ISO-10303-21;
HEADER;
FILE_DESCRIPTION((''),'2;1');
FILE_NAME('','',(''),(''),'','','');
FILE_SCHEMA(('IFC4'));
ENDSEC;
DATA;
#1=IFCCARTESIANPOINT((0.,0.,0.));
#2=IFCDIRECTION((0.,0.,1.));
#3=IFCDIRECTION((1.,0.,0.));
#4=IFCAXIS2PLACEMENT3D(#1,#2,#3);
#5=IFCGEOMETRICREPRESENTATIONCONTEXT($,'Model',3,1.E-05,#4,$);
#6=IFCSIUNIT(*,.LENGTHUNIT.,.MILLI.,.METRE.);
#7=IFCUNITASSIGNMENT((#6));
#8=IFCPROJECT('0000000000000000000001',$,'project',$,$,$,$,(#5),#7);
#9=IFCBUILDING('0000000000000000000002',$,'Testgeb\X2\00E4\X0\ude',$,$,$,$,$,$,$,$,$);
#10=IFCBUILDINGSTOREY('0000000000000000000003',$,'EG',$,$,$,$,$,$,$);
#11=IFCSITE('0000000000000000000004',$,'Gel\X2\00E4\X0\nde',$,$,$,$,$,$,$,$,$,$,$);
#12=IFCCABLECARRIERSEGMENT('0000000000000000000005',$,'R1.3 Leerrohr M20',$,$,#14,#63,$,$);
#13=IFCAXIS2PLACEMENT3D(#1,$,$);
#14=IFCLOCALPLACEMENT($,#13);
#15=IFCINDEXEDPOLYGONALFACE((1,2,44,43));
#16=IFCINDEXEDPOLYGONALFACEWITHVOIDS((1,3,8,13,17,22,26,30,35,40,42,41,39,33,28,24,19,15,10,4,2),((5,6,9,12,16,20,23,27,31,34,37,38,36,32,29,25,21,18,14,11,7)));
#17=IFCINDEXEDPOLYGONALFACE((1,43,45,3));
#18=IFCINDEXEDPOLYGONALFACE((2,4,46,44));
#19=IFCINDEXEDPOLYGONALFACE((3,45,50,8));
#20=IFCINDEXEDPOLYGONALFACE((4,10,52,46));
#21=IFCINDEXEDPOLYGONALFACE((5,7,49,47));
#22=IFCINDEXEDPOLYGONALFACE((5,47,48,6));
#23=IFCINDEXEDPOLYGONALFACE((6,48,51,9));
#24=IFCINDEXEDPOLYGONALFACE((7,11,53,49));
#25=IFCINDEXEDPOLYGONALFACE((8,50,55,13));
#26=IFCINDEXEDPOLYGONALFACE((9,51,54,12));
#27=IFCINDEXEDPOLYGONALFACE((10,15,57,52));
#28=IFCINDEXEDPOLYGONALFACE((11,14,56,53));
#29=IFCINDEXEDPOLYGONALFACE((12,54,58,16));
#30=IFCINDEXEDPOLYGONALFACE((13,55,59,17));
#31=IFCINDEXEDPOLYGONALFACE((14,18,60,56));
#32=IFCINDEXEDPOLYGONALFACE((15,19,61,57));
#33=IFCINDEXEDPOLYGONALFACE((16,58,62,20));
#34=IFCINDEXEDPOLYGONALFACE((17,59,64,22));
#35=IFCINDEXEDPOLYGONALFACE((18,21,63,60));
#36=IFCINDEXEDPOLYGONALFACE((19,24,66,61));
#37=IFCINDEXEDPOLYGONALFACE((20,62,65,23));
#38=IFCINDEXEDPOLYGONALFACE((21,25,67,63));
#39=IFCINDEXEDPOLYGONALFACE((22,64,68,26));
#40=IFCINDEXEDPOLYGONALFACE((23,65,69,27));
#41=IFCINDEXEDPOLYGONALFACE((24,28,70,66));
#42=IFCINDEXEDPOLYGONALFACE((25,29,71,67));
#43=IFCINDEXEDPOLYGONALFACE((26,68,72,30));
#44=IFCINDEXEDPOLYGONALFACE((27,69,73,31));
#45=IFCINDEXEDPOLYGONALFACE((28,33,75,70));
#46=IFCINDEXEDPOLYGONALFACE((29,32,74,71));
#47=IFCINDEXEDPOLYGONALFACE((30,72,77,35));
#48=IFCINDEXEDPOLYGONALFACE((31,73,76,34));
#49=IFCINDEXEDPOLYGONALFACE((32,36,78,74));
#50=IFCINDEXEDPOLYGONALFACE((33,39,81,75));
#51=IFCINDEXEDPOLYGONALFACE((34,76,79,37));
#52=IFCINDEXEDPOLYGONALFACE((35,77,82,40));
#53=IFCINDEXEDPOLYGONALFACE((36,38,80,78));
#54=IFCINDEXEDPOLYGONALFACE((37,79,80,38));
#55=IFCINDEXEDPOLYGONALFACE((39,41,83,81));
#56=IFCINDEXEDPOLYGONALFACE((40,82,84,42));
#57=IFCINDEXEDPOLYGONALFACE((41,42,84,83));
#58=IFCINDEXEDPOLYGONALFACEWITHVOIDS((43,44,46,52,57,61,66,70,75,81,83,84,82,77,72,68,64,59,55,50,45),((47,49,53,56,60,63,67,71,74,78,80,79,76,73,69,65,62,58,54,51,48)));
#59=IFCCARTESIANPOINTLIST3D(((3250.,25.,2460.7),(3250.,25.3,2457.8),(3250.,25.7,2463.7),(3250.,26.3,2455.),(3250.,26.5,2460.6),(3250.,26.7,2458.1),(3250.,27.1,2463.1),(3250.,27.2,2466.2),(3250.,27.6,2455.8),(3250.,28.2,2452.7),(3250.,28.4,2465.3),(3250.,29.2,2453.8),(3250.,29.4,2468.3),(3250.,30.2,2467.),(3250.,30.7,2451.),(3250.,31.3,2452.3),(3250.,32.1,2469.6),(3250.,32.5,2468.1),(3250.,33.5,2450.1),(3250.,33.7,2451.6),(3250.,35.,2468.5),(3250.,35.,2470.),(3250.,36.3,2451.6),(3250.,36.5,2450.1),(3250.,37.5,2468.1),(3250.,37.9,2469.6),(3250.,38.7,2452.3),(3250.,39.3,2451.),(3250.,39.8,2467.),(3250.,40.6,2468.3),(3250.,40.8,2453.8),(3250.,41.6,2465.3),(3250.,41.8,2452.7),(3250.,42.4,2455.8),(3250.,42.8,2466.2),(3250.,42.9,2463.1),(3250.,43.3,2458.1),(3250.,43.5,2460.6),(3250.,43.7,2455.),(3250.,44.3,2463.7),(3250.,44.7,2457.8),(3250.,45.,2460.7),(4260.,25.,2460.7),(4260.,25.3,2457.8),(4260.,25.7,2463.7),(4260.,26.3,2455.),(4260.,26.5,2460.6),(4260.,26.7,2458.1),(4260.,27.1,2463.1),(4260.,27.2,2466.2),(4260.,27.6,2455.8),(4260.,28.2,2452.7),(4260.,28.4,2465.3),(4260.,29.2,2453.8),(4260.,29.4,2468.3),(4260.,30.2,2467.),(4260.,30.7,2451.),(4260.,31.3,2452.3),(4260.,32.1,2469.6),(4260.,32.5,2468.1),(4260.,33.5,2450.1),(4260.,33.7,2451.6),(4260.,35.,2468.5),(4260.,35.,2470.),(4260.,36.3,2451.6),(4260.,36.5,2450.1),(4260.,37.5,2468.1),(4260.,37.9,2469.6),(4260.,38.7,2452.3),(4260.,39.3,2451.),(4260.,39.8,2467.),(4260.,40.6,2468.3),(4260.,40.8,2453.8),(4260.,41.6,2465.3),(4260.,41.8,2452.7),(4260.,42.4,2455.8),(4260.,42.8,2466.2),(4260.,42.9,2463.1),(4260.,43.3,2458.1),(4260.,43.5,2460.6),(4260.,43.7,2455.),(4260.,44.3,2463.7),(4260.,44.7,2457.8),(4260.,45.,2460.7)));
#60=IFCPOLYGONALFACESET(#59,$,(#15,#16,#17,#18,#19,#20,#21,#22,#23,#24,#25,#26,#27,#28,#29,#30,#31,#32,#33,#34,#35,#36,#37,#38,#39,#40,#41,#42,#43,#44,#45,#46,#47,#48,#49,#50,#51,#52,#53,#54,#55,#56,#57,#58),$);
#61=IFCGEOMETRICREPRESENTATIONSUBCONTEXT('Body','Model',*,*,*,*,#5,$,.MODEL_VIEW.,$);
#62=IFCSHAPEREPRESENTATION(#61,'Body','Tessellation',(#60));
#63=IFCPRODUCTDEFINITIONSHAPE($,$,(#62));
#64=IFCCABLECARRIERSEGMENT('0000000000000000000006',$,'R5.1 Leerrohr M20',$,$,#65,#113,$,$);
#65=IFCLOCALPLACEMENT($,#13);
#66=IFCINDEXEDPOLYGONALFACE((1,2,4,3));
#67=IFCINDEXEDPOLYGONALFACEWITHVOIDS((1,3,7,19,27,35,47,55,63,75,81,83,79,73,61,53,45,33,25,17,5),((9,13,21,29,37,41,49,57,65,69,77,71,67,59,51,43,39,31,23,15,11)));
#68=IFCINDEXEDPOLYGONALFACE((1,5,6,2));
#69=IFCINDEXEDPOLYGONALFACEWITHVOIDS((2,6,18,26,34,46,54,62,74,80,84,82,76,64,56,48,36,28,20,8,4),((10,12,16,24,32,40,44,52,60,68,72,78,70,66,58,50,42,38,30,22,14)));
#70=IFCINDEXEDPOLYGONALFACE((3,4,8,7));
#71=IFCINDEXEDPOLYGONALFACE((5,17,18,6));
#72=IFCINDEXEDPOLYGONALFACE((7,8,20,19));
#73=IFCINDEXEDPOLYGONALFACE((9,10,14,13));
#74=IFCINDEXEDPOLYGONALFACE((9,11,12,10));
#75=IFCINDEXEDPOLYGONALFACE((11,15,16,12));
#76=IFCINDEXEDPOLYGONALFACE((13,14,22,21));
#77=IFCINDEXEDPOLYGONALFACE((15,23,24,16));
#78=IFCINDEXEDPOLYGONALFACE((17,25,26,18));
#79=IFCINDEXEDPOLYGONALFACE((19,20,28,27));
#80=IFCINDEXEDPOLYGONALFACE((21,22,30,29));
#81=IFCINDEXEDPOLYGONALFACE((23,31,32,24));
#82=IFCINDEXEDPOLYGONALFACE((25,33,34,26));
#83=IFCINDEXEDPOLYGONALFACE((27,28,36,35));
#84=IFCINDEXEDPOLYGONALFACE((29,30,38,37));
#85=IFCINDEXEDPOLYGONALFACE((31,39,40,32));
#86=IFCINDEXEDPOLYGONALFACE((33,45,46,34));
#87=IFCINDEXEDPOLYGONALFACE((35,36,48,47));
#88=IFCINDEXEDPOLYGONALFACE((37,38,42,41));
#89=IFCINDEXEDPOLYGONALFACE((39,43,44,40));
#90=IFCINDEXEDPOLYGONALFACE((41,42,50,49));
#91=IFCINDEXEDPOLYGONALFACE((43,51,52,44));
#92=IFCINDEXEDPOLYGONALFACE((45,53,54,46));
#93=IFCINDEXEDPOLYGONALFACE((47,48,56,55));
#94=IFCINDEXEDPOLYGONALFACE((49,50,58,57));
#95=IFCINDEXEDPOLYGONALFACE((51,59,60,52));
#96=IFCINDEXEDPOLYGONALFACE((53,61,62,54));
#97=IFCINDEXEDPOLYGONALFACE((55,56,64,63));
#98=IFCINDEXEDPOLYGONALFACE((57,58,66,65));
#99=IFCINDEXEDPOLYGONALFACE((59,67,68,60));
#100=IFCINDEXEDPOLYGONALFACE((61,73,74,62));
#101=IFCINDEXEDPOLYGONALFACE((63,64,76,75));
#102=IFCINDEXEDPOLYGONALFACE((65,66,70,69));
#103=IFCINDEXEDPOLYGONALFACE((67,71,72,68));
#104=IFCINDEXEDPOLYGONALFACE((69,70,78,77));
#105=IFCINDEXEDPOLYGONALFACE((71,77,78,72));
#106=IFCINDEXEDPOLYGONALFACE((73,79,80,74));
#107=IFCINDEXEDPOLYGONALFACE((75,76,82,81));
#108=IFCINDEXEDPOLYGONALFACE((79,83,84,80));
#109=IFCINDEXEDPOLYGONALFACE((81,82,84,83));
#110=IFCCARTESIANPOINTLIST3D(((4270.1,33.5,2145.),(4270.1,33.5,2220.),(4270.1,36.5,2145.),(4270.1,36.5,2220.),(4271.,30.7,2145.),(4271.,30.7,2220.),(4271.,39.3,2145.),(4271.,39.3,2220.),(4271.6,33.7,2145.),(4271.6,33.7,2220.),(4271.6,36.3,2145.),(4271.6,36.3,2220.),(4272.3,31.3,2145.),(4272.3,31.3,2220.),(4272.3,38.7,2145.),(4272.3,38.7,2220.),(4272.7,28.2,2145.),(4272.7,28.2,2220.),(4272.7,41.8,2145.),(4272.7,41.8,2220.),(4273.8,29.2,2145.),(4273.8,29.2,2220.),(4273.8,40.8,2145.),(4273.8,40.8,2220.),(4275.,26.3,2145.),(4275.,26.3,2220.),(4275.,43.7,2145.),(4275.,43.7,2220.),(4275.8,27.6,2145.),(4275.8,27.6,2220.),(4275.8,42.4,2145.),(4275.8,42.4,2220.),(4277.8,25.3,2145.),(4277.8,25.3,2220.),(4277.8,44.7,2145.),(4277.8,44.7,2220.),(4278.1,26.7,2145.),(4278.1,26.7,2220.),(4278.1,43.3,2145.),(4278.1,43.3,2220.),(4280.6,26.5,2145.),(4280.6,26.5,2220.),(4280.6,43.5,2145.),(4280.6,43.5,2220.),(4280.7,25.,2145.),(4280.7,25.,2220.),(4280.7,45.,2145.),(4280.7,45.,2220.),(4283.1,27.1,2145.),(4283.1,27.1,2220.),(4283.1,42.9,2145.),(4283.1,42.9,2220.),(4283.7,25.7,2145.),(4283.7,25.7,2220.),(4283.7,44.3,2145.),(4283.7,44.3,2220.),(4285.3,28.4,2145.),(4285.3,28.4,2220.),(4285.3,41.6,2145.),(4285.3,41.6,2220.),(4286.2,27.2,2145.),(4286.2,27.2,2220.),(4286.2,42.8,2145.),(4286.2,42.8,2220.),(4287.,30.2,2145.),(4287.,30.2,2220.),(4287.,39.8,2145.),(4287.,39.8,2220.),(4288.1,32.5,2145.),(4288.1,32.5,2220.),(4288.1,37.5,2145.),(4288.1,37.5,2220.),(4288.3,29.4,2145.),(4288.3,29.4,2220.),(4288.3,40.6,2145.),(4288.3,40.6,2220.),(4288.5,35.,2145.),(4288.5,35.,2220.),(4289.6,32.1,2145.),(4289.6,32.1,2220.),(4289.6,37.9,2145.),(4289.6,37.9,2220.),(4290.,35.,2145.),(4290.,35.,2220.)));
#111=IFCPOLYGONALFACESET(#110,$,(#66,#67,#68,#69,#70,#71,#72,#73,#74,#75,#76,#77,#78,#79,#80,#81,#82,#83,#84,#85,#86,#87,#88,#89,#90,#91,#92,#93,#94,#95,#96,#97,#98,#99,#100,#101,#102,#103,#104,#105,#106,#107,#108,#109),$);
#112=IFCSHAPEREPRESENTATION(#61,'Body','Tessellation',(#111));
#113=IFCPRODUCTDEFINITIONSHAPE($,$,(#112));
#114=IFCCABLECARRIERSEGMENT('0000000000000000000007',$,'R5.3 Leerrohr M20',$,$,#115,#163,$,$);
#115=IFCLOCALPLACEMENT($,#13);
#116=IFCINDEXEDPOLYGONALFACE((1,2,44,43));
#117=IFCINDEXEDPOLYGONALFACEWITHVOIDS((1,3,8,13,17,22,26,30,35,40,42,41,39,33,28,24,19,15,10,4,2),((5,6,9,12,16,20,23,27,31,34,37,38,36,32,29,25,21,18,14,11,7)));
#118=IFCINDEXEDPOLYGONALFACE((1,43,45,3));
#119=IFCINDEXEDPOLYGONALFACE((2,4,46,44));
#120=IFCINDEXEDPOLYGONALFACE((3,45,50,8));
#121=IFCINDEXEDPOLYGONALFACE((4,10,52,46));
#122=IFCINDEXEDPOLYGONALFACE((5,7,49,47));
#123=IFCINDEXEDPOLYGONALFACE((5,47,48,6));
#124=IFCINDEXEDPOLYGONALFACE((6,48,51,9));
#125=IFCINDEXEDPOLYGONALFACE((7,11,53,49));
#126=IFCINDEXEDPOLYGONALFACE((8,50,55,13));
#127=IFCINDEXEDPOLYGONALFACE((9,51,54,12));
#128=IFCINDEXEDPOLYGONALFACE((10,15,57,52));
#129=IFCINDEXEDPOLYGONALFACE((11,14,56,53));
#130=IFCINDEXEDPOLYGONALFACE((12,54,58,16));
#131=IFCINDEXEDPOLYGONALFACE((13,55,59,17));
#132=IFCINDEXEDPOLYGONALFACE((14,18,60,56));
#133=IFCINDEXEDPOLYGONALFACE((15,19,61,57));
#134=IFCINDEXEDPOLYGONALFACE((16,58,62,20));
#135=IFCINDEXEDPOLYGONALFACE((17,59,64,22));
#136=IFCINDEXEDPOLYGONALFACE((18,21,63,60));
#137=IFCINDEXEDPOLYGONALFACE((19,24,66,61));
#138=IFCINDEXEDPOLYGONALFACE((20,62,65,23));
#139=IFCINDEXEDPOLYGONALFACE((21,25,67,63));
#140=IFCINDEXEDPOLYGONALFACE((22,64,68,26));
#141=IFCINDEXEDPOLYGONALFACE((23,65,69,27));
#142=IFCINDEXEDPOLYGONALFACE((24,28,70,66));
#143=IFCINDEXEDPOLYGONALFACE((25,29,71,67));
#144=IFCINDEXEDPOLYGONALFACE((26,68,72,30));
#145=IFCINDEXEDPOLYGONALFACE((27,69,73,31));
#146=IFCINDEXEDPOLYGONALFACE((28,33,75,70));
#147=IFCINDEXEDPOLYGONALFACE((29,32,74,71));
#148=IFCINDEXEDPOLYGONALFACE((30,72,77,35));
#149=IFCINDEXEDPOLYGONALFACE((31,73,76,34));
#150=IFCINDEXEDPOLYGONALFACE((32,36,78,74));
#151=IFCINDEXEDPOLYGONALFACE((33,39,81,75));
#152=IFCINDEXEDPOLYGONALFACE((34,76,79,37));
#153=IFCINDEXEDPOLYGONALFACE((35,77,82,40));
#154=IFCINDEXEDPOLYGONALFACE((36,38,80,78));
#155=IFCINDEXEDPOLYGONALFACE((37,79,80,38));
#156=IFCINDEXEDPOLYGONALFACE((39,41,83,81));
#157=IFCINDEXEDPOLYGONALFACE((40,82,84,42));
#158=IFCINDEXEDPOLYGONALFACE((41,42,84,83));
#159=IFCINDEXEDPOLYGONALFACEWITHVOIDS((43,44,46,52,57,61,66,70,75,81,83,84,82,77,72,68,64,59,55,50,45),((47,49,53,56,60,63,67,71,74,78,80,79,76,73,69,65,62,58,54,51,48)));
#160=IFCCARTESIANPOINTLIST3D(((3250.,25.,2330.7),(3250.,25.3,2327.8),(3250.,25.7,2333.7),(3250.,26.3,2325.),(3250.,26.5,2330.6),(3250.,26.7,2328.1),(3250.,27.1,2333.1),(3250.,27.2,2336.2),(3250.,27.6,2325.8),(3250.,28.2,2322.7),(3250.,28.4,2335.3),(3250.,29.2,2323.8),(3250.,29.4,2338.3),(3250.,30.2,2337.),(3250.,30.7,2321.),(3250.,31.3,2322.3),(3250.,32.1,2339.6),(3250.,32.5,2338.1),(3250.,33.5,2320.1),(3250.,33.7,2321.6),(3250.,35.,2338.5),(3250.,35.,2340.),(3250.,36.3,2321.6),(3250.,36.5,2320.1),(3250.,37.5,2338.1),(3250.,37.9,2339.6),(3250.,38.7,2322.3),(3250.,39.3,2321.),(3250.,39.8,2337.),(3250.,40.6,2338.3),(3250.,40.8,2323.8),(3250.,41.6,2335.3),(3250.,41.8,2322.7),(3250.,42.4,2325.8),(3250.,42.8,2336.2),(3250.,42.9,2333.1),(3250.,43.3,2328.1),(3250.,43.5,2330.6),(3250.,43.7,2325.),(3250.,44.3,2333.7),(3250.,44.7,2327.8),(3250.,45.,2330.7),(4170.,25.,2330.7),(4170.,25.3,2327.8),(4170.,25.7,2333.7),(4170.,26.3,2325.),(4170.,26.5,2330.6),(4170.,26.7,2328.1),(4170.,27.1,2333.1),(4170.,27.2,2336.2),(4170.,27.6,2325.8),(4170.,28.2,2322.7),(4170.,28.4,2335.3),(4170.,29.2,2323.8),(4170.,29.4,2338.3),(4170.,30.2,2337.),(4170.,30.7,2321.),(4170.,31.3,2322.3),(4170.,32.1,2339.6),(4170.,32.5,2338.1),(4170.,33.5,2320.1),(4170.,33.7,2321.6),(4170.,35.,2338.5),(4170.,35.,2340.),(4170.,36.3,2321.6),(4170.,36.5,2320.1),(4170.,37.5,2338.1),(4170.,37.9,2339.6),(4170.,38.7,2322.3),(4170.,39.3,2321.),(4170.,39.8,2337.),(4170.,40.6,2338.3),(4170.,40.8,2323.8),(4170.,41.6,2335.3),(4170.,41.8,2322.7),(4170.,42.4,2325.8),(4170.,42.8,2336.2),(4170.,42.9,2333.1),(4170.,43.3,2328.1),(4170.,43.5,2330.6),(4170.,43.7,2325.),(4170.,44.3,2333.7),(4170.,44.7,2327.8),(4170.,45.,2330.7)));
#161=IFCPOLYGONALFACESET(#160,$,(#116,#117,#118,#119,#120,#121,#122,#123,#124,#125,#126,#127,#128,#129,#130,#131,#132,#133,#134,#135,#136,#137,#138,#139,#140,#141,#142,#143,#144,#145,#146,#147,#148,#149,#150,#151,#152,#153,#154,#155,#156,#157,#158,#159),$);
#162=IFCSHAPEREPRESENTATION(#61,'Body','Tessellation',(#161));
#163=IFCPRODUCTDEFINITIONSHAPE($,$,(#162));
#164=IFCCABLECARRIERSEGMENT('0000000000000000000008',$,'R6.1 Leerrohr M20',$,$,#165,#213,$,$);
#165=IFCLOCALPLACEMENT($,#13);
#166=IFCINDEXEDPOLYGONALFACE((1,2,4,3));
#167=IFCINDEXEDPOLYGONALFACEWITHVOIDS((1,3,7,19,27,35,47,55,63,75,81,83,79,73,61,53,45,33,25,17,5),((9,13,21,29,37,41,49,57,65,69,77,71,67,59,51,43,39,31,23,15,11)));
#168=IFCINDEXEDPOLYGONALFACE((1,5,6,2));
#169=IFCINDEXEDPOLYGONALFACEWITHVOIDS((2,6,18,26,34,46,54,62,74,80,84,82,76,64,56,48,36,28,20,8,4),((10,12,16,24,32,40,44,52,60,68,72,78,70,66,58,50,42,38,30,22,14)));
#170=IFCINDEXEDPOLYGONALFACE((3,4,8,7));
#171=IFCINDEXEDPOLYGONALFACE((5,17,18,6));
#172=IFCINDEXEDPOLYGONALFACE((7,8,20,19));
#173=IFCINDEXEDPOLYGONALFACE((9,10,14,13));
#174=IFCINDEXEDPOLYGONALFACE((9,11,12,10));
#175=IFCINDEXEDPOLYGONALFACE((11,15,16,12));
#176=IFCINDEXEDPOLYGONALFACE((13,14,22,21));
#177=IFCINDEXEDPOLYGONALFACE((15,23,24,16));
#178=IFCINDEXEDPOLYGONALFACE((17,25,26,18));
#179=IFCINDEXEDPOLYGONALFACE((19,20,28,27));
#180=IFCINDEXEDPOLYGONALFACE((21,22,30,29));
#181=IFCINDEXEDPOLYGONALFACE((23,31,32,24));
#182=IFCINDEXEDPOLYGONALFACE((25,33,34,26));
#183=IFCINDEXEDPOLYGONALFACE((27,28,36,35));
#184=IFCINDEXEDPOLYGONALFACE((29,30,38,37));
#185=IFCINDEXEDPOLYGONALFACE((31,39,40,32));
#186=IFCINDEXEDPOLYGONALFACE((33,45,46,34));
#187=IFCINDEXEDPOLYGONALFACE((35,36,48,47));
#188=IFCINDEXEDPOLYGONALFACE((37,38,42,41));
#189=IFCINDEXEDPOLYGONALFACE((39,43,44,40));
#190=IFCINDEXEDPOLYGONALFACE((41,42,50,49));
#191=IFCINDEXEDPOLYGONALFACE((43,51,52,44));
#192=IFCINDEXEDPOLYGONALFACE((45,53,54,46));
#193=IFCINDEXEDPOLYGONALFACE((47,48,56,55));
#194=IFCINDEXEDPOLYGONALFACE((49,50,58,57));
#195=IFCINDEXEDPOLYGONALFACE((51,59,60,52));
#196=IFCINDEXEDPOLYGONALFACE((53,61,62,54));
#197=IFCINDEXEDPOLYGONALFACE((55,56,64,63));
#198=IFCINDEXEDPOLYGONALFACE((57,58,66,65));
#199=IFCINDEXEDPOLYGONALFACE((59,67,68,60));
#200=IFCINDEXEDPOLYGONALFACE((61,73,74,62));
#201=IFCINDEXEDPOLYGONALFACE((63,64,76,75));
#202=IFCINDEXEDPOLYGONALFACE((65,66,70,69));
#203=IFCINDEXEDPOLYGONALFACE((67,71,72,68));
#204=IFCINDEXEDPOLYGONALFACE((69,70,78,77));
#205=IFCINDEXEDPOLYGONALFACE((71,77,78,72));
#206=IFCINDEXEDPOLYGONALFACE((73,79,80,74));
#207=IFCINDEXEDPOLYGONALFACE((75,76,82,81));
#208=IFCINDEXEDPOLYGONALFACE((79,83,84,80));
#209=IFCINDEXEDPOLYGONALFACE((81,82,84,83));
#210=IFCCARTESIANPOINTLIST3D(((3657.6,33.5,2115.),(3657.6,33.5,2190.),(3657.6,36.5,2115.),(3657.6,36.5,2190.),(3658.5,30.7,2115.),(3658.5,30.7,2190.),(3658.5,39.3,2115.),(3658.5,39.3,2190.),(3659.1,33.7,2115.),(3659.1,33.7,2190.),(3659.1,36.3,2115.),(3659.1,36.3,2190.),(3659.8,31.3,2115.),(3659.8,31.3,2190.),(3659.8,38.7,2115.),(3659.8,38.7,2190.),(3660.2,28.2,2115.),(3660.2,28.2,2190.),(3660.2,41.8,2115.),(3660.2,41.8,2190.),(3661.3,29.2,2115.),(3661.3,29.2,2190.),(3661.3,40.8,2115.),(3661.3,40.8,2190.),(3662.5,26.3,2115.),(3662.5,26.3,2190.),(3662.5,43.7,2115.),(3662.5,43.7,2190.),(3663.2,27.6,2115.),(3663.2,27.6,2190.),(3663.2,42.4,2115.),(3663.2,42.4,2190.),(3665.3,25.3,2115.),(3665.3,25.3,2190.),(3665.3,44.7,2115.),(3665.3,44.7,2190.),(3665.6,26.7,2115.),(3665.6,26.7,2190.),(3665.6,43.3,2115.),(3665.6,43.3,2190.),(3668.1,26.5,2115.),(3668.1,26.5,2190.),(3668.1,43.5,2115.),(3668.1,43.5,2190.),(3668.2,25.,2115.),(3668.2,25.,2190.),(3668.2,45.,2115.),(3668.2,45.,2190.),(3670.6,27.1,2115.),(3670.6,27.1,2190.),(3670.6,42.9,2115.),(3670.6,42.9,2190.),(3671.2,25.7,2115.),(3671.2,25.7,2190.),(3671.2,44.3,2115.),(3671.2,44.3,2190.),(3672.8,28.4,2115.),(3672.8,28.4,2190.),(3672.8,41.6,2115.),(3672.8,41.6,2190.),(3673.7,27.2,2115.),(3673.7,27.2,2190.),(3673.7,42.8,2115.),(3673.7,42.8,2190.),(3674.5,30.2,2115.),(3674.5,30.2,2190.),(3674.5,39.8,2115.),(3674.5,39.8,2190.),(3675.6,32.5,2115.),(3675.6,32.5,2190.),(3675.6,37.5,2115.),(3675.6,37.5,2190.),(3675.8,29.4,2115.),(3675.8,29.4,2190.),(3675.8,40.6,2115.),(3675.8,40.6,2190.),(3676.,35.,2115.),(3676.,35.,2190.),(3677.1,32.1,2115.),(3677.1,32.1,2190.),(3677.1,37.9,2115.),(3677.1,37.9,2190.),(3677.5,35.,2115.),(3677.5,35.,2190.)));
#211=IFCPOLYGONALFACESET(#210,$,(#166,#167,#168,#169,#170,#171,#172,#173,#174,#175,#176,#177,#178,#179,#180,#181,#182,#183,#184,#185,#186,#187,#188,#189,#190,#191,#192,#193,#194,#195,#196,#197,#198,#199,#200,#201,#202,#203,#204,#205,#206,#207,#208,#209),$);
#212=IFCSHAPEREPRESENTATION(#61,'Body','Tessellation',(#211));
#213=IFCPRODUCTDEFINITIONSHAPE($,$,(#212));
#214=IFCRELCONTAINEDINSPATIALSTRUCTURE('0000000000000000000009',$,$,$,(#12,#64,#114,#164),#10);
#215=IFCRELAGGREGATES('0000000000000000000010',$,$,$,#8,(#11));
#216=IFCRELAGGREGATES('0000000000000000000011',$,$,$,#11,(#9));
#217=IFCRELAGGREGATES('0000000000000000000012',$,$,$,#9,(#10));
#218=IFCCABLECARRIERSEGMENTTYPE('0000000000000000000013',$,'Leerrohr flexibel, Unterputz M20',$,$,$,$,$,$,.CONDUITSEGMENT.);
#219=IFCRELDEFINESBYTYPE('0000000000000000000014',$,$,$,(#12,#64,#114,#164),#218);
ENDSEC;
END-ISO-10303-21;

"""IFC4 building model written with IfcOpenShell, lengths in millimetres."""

from ifc_helpers import new_model, si_unit, frame, origin_with_axes, place, context, subcontext, project, spatial, hollow_circle, extrude, type_object, element, save


model = new_model("IFC4")

# Units and contexts
model_context = context("Model", 3, precision=1e-05, world=origin_with_axes())
body_context = subcontext(model_context, "Body", "Model", "MODEL_VIEW")
ifc_project = project(units=[si_unit("LENGTHUNIT", "METRE", prefix="MILLI")], contexts=[model_context])

# Site, building, storey
site = spatial("IfcSite", under=ifc_project, Name="Gelände")
building = spatial("IfcBuilding", under=site, Name="Testgebäude")
storey = spatial("IfcBuildingStorey", under=building, Name="EG")

# Cable carrier segments
cable_carrier_segment_type_1 = type_object("IfcCableCarrierSegmentType", Name="Leerrohr flexibel, Unterputz M20", PredefinedType="CONDUITSEGMENT")
cable_carrier_segment_1_placement = place(None, frame((4260.0, 35.0, 2460.0), z_axis=(-1.0, 0.0, 0.0), x_axis=(0.0, 0.0, 1.0)))
element("IfcCableCarrierSegment", 1, at=cable_carrier_segment_1_placement, inside=storey, type_object=cable_carrier_segment_type_1, Name="R1.3 Leerrohr M20", context=body_context, shape_type="SweptSolid", body=[
    extrude(hollow_circle(Radius=10.0, WallThickness=1.5), None, (0.0, 0.0, 1.0), 1010.0),
])
cable_carrier_segment_2_placement = place(None, frame((4280.0, 35.0, 2145.0), z_axis=(0.0, 0.0, 1.0), x_axis=(1.0, 0.0, 0.0)))
element("IfcCableCarrierSegment", 2, at=cable_carrier_segment_2_placement, inside=storey, type_object=cable_carrier_segment_type_1, Name="R5.1 Leerrohr M20", context=body_context, shape_type="SweptSolid", body=[
    extrude(hollow_circle(Radius=10.0, WallThickness=1.5), None, (0.0, 0.0, 1.0), 75.0),
])
cable_carrier_segment_3_placement = place(None, frame((4170.0, 35.0, 2330.0), z_axis=(-1.0, 0.0, 0.0), x_axis=(0.0, 0.0, 1.0)))
element("IfcCableCarrierSegment", 3, at=cable_carrier_segment_3_placement, inside=storey, type_object=cable_carrier_segment_type_1, Name="R5.3 Leerrohr M20", context=body_context, shape_type="SweptSolid", body=[
    extrude(hollow_circle(Radius=10.0, WallThickness=1.5), None, (0.0, 0.0, 1.0), 920.0),
])
cable_carrier_segment_4_placement = place(None, frame((3667.5, 35.0, 2115.0), z_axis=(0.0, 0.0, 1.0), x_axis=(1.0, 0.0, 0.0)))
element("IfcCableCarrierSegment", 4, at=cable_carrier_segment_4_placement, inside=storey, type_object=cable_carrier_segment_type_1, Name="R6.1 Leerrohr M20", context=body_context, shape_type="SweptSolid", body=[
    extrude(hollow_circle(Radius=10.0, WallThickness=1.5), None, (0.0, 0.0, 1.0), 75.0),
])

save(model, "model.ifc")
